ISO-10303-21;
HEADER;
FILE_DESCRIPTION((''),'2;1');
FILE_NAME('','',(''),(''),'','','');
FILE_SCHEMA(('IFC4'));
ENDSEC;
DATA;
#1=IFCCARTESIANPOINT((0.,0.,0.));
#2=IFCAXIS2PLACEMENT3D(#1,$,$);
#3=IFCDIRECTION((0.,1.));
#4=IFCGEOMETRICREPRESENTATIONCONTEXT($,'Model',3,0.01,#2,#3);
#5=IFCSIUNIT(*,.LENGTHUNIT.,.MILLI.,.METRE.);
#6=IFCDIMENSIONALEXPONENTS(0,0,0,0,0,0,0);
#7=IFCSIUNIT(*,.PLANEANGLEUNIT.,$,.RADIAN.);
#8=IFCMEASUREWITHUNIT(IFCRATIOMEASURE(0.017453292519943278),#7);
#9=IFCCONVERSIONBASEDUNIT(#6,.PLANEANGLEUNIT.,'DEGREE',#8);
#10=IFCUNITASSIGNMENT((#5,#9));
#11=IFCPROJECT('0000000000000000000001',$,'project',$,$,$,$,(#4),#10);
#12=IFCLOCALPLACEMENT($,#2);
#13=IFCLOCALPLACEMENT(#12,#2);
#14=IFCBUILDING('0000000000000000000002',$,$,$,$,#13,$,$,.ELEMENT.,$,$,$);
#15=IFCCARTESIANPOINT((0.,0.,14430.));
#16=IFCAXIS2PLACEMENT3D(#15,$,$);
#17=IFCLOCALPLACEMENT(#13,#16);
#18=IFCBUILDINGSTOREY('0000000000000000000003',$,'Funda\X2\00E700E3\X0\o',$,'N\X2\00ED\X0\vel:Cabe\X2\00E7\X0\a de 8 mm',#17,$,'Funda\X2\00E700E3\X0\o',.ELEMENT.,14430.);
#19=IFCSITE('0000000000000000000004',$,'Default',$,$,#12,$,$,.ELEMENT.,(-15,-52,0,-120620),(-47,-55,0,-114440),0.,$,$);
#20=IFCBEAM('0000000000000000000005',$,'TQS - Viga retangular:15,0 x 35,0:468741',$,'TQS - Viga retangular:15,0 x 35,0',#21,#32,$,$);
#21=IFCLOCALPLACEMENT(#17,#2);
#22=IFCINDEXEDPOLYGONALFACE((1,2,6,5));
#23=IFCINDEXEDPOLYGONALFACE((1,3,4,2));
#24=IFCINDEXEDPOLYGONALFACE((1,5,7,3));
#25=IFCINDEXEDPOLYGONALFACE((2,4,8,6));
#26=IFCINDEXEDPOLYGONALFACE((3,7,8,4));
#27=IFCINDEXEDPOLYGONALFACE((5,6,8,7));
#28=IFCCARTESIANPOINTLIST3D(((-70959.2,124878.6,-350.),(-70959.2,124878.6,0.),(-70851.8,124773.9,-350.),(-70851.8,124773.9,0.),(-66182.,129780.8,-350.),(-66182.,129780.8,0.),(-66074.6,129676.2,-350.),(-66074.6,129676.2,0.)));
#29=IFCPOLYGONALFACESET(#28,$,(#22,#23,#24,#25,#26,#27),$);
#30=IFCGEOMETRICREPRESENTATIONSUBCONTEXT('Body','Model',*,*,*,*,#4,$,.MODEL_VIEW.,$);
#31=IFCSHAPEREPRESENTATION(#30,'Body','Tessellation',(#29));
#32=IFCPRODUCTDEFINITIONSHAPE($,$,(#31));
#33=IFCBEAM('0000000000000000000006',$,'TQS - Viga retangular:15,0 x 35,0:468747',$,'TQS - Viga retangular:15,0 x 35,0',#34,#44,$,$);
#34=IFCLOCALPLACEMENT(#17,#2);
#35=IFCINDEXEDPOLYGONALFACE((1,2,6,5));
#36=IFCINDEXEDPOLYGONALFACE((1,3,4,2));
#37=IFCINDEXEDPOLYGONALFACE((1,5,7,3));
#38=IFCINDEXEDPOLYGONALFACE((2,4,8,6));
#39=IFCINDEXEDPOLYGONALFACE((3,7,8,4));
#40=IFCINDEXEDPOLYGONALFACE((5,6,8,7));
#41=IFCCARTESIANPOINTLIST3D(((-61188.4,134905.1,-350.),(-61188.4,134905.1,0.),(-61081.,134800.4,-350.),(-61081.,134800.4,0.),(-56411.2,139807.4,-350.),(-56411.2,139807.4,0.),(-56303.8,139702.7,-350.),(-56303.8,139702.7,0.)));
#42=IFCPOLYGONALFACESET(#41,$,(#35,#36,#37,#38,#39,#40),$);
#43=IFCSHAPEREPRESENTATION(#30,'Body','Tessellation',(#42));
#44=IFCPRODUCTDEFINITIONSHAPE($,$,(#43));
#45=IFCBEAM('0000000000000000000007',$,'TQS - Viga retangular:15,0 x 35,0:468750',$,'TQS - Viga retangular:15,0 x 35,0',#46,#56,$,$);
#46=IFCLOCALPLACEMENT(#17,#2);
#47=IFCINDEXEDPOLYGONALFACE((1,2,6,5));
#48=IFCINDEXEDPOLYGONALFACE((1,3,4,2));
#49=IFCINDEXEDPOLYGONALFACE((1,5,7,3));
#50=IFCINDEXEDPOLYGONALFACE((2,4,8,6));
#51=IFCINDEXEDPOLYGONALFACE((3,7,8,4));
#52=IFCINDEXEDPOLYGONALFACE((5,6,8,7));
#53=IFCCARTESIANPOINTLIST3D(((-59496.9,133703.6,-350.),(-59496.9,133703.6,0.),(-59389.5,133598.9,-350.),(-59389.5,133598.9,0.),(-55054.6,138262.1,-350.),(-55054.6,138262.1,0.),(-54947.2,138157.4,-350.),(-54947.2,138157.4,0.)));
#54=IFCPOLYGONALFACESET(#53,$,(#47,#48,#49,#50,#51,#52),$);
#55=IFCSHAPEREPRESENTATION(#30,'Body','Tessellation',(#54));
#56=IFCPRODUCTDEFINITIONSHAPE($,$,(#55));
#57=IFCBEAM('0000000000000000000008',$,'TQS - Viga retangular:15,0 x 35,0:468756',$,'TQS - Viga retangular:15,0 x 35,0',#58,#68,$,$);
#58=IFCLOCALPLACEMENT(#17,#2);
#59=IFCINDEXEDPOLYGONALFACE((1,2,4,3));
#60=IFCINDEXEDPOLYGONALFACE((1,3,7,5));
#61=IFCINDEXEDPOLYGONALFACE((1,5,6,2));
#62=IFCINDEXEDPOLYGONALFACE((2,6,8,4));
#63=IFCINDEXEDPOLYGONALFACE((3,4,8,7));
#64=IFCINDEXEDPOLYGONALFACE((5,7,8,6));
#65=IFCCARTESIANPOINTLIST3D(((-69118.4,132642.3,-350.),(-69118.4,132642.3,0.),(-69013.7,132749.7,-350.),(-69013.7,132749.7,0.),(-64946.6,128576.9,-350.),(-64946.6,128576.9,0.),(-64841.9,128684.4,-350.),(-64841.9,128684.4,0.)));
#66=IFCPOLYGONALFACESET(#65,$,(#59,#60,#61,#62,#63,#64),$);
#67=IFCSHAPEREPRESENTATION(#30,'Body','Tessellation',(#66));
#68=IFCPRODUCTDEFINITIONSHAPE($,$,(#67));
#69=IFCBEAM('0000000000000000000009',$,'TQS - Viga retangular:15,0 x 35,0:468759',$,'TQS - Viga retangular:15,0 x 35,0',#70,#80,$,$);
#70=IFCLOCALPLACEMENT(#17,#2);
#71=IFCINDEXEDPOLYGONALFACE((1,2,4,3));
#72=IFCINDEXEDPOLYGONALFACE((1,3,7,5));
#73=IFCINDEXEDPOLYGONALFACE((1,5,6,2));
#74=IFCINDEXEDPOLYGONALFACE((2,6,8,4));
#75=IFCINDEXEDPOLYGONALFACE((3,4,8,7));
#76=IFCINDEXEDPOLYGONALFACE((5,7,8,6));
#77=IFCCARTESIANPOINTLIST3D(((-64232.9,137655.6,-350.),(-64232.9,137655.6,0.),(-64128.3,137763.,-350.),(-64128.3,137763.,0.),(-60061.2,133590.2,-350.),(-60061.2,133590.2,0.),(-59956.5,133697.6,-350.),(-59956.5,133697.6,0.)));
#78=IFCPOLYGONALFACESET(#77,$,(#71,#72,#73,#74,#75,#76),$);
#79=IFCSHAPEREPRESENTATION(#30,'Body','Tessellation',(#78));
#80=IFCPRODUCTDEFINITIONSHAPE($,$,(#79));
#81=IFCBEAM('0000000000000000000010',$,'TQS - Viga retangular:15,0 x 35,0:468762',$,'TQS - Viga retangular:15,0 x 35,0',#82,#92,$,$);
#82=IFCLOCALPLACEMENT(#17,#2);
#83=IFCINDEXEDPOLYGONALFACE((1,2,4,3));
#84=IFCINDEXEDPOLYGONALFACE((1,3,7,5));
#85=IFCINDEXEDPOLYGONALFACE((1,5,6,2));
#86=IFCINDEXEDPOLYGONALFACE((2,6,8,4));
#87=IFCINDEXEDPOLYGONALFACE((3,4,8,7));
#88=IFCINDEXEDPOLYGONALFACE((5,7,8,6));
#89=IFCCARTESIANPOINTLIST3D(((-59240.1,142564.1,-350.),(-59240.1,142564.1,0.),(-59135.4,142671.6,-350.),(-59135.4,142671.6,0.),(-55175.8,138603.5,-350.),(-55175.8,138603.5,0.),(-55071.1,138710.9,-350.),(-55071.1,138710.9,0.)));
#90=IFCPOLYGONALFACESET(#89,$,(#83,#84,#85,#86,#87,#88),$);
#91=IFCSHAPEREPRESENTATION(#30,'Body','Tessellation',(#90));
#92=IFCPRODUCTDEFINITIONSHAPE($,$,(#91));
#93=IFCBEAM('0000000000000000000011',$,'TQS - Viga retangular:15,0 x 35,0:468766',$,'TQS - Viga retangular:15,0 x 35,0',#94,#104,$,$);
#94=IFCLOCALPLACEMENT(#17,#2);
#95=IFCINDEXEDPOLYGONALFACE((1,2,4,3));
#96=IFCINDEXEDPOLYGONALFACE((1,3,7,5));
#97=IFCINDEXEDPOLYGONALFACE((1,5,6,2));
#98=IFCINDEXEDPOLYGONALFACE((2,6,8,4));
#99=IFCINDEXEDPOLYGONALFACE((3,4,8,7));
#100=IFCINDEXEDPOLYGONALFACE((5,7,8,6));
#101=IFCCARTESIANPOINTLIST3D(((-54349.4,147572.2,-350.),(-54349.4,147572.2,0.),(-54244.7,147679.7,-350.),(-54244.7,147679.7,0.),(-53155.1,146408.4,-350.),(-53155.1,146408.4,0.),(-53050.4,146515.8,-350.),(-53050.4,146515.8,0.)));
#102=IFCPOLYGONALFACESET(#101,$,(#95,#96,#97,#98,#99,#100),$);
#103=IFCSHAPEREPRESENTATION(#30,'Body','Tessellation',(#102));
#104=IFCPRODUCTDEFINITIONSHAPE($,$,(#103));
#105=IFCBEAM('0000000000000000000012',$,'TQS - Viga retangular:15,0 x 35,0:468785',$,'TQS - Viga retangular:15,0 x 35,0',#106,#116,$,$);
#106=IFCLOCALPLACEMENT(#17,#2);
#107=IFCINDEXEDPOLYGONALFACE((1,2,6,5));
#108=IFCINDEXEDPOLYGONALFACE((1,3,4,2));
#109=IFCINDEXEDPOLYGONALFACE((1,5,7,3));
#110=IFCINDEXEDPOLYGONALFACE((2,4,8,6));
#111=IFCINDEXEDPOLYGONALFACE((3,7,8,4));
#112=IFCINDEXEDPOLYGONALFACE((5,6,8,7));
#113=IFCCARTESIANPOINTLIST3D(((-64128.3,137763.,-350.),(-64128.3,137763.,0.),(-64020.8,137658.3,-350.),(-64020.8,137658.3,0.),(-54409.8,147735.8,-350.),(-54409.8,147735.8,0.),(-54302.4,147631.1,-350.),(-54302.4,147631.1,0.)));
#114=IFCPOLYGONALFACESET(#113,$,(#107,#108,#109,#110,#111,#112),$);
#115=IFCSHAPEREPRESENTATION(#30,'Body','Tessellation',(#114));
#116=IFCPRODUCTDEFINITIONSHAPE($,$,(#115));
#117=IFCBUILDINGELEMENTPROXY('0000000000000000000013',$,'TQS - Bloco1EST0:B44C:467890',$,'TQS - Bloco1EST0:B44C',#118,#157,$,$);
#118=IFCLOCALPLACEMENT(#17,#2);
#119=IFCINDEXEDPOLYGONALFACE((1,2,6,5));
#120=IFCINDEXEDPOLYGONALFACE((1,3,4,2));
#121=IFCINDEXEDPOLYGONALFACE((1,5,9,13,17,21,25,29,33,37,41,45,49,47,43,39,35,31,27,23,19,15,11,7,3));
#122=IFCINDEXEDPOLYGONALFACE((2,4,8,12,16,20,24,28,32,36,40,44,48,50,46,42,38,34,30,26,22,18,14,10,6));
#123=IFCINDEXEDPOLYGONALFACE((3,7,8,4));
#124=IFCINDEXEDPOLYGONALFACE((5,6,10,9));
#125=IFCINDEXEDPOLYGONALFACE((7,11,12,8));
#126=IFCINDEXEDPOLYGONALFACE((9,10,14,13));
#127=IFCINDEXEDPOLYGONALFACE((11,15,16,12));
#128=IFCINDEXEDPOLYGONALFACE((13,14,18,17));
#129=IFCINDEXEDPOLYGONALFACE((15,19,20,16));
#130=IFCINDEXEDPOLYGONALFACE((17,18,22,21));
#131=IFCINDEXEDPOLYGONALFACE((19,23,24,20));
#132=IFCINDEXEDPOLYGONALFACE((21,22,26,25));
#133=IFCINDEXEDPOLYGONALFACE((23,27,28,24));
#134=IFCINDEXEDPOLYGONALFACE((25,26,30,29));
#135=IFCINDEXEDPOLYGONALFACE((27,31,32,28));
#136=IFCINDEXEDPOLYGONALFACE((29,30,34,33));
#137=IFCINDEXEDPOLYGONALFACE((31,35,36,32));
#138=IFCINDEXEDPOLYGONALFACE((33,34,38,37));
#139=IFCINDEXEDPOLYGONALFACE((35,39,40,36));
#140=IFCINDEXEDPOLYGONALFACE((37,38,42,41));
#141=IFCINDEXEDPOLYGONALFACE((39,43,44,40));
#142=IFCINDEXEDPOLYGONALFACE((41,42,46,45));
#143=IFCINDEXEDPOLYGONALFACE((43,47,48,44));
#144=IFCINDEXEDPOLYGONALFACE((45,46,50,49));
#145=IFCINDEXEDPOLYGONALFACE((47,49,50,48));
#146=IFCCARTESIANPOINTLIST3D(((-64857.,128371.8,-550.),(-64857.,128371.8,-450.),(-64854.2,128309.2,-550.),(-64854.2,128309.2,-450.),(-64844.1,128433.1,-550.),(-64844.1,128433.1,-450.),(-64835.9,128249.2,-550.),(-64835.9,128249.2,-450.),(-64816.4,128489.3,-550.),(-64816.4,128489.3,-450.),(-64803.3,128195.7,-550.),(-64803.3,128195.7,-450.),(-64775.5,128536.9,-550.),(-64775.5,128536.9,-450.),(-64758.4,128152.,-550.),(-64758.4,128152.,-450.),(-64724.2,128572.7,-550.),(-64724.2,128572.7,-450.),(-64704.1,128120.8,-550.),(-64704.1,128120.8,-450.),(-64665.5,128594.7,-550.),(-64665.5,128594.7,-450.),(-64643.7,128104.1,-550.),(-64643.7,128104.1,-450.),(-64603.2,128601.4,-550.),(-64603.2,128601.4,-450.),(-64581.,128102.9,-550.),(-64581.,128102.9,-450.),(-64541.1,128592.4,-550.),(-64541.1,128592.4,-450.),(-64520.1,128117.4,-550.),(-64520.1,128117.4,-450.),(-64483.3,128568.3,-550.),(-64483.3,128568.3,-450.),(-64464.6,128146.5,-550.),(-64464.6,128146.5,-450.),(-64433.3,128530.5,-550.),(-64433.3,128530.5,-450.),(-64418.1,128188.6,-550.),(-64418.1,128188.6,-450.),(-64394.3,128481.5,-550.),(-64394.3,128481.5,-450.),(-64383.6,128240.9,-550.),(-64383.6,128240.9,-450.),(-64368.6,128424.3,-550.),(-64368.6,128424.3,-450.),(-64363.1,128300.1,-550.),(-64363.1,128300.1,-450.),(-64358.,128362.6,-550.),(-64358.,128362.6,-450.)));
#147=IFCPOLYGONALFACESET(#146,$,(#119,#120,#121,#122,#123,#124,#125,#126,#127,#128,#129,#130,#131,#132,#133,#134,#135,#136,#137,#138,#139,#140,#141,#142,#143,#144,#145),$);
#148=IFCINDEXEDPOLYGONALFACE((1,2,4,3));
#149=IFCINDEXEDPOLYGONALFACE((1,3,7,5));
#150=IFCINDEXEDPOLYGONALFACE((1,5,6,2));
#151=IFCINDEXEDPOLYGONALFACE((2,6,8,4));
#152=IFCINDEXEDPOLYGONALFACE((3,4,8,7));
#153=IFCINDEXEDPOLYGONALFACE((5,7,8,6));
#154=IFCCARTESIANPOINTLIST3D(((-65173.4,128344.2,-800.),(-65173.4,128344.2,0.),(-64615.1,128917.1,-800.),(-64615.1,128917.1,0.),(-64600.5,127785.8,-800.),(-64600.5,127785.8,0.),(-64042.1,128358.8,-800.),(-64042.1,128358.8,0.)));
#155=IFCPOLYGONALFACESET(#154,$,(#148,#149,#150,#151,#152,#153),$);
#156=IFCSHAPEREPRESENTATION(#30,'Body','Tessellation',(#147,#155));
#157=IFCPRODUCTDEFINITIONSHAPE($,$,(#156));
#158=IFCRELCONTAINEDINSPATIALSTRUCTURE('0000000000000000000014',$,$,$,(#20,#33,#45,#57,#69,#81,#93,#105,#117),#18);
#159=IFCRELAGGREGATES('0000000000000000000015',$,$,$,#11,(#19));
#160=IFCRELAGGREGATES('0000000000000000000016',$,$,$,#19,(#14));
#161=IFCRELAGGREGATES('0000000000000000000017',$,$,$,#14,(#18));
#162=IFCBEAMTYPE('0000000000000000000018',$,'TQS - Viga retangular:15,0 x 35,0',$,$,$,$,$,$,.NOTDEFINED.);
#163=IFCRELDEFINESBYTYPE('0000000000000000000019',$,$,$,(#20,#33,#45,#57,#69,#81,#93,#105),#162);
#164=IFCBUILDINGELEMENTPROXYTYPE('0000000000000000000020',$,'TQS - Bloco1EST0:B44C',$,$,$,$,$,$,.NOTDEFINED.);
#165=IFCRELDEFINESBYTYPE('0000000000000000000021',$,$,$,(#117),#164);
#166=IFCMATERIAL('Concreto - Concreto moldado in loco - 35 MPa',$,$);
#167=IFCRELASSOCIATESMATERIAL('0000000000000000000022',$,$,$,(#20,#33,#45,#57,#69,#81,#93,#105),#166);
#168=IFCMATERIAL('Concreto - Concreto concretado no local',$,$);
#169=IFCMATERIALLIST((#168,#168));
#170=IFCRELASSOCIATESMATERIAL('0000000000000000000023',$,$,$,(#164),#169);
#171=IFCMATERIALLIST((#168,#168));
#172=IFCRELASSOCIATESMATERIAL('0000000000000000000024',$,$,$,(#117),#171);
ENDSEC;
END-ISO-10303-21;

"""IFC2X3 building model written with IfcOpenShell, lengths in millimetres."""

from ifc_helpers import new_model, entity, si_unit, converted_unit, direction, frame, frame_2d, origin, origin_2d_with_axis, place, context, subcontext, project, spatial, rectangle, circle, extrude, source, transform, mapped, material, material_list, type_object, type_shapes, element, save


model = new_model("IFC2X3")

# Units and contexts
model_context = context("Model", 3, precision=0.01, world=origin(), true_north=direction((0.0, 1.0)))
body_context = subcontext(model_context, "Body", "Model", "MODEL_VIEW")
ifc_project = project(units=[si_unit("LENGTHUNIT", "METRE", prefix="MILLI"), converted_unit("PLANEANGLEUNIT", "DEGREE", entity("IfcRatioMeasure", 0.017453292519943278), si_unit("PLANEANGLEUNIT", "RADIAN"), dimensions=[0, 0, 0, 0, 0, 0, 0])], contexts=[model_context])

# Site, building, storey
site_placement = place(None, origin())
site = spatial("IfcSite", under=ifc_project, at=site_placement, Name="Default", CompositionType="ELEMENT", RefLatitude=(-15, -52, 0, -120620), RefLongitude=(-47, -55, 0, -114440), RefElevation=0.0)
building_placement = place(site_placement, origin())
building = spatial("IfcBuilding", under=site, at=building_placement, CompositionType="ELEMENT")
storey_placement = place(building_placement, frame((0.0, 0.0, 14430.0)))
storey = spatial("IfcBuildingStorey", under=building, at=storey_placement, Name="Fundação", ObjectType="Nível:Cabeça de 8 mm", LongName="Fundação", CompositionType="ELEMENT", Elevation=14430.0)

# Beams
ifc_material_1 = material(Name="Concreto - Concreto moldado in loco - 35 MPa")
beam_type = type_object("IfcBeamType", Name="TQS - Viga retangular:15,0 x 35,0", PredefinedType="NOTDEFINED")
beam_1_placement = place(storey_placement, frame((-70905.5, 124826.2, 0.0), z_axis=(0.0, 0.0, 1.0), x_axis=(0.697915, 0.71618, 0.0)))
element("IfcBeam", 1, at=beam_1_placement, inside=storey, type_object=beam_type, material=ifc_material_1, Name="TQS - Viga retangular:15,0 x 35,0:468741", ObjectType="TQS - Viga retangular:15,0 x 35,0", context=body_context, shape_type="SweptSolid", body=[
    extrude(rectangle(XDim=350.0, YDim=150.0, at=frame_2d((0.0, 0.0), x_axis=(1.0, 0.0))), frame((0.0, 0.0, -175.0), z_axis=(1.0, 0.0, 0.0), x_axis=(0.0, 0.0, -1.0)), (0.0, 0.0, 1.0), 6845.0),
])
beam_2_placement = place(storey_placement, frame((-61134.7, 134852.8, 0.0), z_axis=(0.0, 0.0, 1.0), x_axis=(0.697915, 0.71618, 0.0)))
element("IfcBeam", 2, at=beam_2_placement, inside=storey, type_object=beam_type, material=ifc_material_1, Name="TQS - Viga retangular:15,0 x 35,0:468747", ObjectType="TQS - Viga retangular:15,0 x 35,0", context=body_context, shape_type="SweptSolid", body=[
    extrude(rectangle(XDim=350.0, YDim=150.0, at=frame_2d((0.0, 0.0), x_axis=(1.0, 0.0))), frame((0.0, 0.0, -175.0), z_axis=(1.0, 0.0, 0.0), x_axis=(0.0, 0.0, -1.0)), (0.0, 0.0, 1.0), 6845.0),
])
beam_3_placement = place(storey_placement, frame((-59443.2, 133651.2, 0.0), z_axis=(0.0, 0.0, 1.0), x_axis=(0.697915, 0.71618, 0.0)))
element("IfcBeam", 3, at=beam_3_placement, inside=storey, type_object=beam_type, material=ifc_material_1, Name="TQS - Viga retangular:15,0 x 35,0:468750", ObjectType="TQS - Viga retangular:15,0 x 35,0", context=body_context, shape_type="SweptSolid", body=[
    extrude(rectangle(XDim=350.0, YDim=150.0, at=frame_2d((0.0, 0.0), x_axis=(1.0, 0.0))), frame((0.0, 0.0, -175.0), z_axis=(1.0, 0.0, 0.0), x_axis=(0.0, 0.0, -1.0)), (0.0, 0.0, 1.0), 6365.1),
])
beam_4_placement = place(storey_placement, frame((-64894.3, 128630.6, 0.0), z_axis=(0.0, 0.0, 1.0), x_axis=(-0.71618, 0.697915, 0.0)))
element("IfcBeam", 4, at=beam_4_placement, inside=storey, type_object=beam_type, material=ifc_material_1, Name="TQS - Viga retangular:15,0 x 35,0:468756", ObjectType="TQS - Viga retangular:15,0 x 35,0", context=body_context, shape_type="SweptSolid", body=[
    extrude(rectangle(XDim=350.0, YDim=150.0, at=frame_2d((0.0, 0.0), x_axis=(1.0, 0.0))), frame((0.0, 0.0, -175.0), z_axis=(1.0, 0.0, 0.0), x_axis=(0.0, 0.0, -1.0)), (0.0, 0.0, 1.0), 5825.0),
])
beam_5_placement = place(storey_placement, frame((-60008.8, 133643.9, 0.0), z_axis=(0.0, 0.0, 1.0), x_axis=(-0.71618, 0.697915, 0.0)))
element("IfcBeam", 5, at=beam_5_placement, inside=storey, type_object=beam_type, material=ifc_material_1, Name="TQS - Viga retangular:15,0 x 35,0:468759", ObjectType="TQS - Viga retangular:15,0 x 35,0", context=body_context, shape_type="SweptSolid", body=[
    extrude(rectangle(XDim=350.0, YDim=150.0, at=frame_2d((0.0, 0.0), x_axis=(1.0, 0.0))), frame((0.0, 0.0, -175.0), z_axis=(1.0, 0.0, 0.0), x_axis=(0.0, 0.0, -1.0)), (0.0, 0.0, 1.0), 5825.0),
])
beam_6_placement = place(storey_placement, frame((-55123.4, 138657.2, 0.0), z_axis=(0.0, 0.0, 1.0), x_axis=(-0.71618, 0.697915, 0.0)))
element("IfcBeam", 6, at=beam_6_placement, inside=storey, type_object=beam_type, material=ifc_material_1, Name="TQS - Viga retangular:15,0 x 35,0:468762", ObjectType="TQS - Viga retangular:15,0 x 35,0", context=body_context, shape_type="SweptSolid", body=[
    extrude(rectangle(XDim=350.0, YDim=150.0, at=frame_2d((0.0, 0.0), x_axis=(1.0, 0.0))), frame((0.0, 0.0, -175.0), z_axis=(1.0, 0.0, 0.0), x_axis=(0.0, 0.0, -1.0)), (0.0, 0.0, 1.0), 5675.0),
])
beam_7_placement = place(storey_placement, frame((-53102.8, 146462.1, 0.0), z_axis=(0.0, 0.0, 1.0), x_axis=(-0.71618, 0.697915, 0.0)))
element("IfcBeam", 7, at=beam_7_placement, inside=storey, type_object=beam_type, material=ifc_material_1, Name="TQS - Viga retangular:15,0 x 35,0:468766", ObjectType="TQS - Viga retangular:15,0 x 35,0", context=body_context, shape_type="SweptSolid", body=[
    extrude(rectangle(XDim=350.0, YDim=150.0, at=frame_2d((0.0, 0.0), x_axis=(1.0, 0.0))), frame((0.0, 0.0, -175.0), z_axis=(1.0, 0.0, 0.0), x_axis=(0.0, 0.0, -1.0)), (0.0, 0.0, 1.0), 1667.6),
])
beam_8_placement = place(storey_placement, frame((-64126.9, 137656.9, 0.0), z_axis=(0.0, 0.0, 1.0), x_axis=(0.697915, 0.71618, 0.0)))
element("IfcBeam", 8, at=beam_8_placement, inside=storey, type_object=beam_type, material=ifc_material_1, Name="TQS - Viga retangular:15,0 x 35,0:468785", ObjectType="TQS - Viga retangular:15,0 x 35,0", context=body_context, shape_type="SweptSolid", body=[
    extrude(rectangle(XDim=350.0, YDim=150.0, at=frame_2d((0.0, 0.0), x_axis=(1.0, 0.0))), frame((75.0, 0.0, -175.0), z_axis=(1.0, 0.0, 0.0), x_axis=(0.0, 0.0, -1.0)), (0.0, 0.0, 1.0), 13925.0),
])

# Building element proxy
ifc_material_2 = material(Name="Concreto - Concreto concretado no local")
ifc_material_list_1 = material_list([ifc_material_2, ifc_material_2])
ifc_material_list_2 = material_list([ifc_material_2, ifc_material_2])
building_element_proxy_type_1 = type_object("IfcBuildingElementProxyType", Name="TQS - Bloco1EST0:B44C", PredefinedType="NOTDEFINED", material=ifc_material_list_2)
shared_shape_1 = source(origin(), body_context, "Body", "SweptSolid", [
    extrude(circle(Radius=250.0, at=frame_2d((0.0, 0.0), x_axis=(1.0, 0.0))), frame((0.0, 0.0, -550.0)), (0.0, 0.0, 1.0), 100.0),
    extrude(rectangle(XDim=800.0, YDim=800.0, at=origin_2d_with_axis()), frame((0.0, 0.0, -800.0), z_axis=(0.0, 0.0, 1.0), x_axis=(-1.0, 0.0, 0.0)), (0.0, 0.0, 1.0), 800.0),
])
type_shapes(building_element_proxy_type_1, [shared_shape_1])
proxy_1_placement = place(storey_placement, frame((-64607.8, 128351.5, 0.0), z_axis=(0.0, 0.0, 1.0), x_axis=(0.697915, 0.71618, 0.0)))
element("IfcBuildingElementProxy", 9, at=proxy_1_placement, inside=storey, type_object=building_element_proxy_type_1, material=ifc_material_list_1, Name="TQS - Bloco1EST0:B44C:467890", ObjectType="TQS - Bloco1EST0:B44C", context=body_context, shape_type="MappedRepresentation", body=[
    mapped(shared_shape_1, transform((0.0, 0.0, 0.0), scale=1.0)),
])

save(model, "model.ifc")
